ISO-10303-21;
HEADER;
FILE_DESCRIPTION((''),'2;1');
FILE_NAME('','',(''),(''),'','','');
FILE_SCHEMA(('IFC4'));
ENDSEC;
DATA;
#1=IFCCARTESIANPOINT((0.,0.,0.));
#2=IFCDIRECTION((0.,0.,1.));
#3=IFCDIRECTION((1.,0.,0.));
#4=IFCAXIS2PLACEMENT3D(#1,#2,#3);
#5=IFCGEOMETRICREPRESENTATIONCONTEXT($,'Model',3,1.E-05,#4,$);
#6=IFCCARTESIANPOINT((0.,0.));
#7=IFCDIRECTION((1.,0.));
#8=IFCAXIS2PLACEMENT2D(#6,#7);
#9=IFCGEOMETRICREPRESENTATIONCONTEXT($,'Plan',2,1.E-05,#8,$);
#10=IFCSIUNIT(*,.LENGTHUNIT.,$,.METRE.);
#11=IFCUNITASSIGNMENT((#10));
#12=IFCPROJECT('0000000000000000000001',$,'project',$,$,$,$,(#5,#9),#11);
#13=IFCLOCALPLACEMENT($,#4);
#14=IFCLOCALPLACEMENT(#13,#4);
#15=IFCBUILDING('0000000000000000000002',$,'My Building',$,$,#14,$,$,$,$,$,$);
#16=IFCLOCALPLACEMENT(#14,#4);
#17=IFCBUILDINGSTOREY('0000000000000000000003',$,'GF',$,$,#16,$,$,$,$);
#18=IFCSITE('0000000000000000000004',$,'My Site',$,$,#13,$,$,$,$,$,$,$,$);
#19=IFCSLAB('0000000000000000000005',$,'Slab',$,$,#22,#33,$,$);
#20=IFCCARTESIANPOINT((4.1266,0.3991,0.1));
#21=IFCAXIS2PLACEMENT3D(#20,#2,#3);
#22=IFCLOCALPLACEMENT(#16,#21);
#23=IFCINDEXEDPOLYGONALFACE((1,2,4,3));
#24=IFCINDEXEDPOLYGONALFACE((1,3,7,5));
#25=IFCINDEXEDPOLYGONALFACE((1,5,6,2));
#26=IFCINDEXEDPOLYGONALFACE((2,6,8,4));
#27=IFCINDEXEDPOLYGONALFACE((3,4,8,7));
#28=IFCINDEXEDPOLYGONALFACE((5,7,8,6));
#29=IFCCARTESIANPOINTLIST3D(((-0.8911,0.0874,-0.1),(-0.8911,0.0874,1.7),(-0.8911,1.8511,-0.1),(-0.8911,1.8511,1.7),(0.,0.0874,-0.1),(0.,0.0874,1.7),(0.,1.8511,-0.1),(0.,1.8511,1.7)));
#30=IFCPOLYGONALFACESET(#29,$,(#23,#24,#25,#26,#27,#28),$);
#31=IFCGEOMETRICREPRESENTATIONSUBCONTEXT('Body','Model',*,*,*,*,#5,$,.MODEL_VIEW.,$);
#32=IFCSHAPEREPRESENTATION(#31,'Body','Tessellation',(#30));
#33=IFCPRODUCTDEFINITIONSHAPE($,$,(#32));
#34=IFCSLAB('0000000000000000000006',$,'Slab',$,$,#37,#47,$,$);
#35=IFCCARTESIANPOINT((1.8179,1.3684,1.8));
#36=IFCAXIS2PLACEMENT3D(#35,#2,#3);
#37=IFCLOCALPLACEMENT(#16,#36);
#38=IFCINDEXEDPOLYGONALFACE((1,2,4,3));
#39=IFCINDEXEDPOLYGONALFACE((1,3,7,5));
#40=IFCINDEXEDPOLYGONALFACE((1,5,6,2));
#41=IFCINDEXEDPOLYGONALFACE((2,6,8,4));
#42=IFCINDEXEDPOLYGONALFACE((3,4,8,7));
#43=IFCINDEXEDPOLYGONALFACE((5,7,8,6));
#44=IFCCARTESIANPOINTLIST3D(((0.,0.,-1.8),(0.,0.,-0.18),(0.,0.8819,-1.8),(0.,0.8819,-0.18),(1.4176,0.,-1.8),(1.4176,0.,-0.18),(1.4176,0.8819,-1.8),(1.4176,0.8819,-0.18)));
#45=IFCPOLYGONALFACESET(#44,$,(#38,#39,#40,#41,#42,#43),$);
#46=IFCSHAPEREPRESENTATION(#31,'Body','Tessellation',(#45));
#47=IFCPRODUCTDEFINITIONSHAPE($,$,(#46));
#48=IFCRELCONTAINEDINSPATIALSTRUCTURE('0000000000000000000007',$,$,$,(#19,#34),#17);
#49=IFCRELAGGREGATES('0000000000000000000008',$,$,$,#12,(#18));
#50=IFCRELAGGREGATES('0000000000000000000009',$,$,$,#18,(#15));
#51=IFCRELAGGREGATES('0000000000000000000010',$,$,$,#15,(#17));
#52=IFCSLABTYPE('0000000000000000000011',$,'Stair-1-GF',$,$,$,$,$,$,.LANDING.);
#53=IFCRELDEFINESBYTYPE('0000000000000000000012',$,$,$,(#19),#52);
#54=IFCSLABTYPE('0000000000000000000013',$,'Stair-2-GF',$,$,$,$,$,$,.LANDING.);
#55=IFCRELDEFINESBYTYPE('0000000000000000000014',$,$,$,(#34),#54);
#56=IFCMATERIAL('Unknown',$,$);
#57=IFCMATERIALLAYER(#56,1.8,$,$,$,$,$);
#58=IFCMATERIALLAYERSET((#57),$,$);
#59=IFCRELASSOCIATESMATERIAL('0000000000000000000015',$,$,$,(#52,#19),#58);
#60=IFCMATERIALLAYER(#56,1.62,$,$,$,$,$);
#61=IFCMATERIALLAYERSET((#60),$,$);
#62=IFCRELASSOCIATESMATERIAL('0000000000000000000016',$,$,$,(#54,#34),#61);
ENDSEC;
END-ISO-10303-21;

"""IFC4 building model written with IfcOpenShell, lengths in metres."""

from ifc_helpers import new_model, si_unit, frame, origin_with_axes, origin_2d_with_axis, place, context, subcontext, project, spatial, indexed_curve, outline, extrude, material, layer, layer_set, layer_usage, type_object, element, save


model = new_model("IFC4")

# Units and contexts
model_context = context("Model", 3, precision=1e-05, world=origin_with_axes())
plan_context = context("Plan", 2, precision=1e-05, world=origin_2d_with_axis())
body_context_1 = subcontext(model_context, "Body", "Model", "MODEL_VIEW")
ifc_project = project(units=[si_unit("LENGTHUNIT", "METRE")], contexts=[model_context, plan_context])

# Site, building, storey
site_placement = place(None, origin_with_axes())
site = spatial("IfcSite", under=ifc_project, at=site_placement, Name="My Site")
building_placement = place(site_placement, origin_with_axes())
building = spatial("IfcBuilding", under=site, at=building_placement, Name="My Building")
storey_placement = place(building_placement, origin_with_axes())
storey = spatial("IfcBuildingStorey", under=building, at=storey_placement, Name="GF")

# Shared definitions
ifc_material = material(Name="Unknown")

# Slabs
ifc_layer_1 = layer(ifc_material, 1.8)
ifc_layer_set_1 = layer_set([ifc_layer_1])
ifc_layer_usage_1 = layer_usage(ifc_layer_set_1, "AXIS3", "POSITIVE", -0.1)
slab_type_1 = type_object("IfcSlabType", Name="Stair-1-GF", PredefinedType="LANDING", material=ifc_layer_set_1)
slab_1_placement = place(storey_placement, frame((4.1266, 0.3991, 0.1), z_axis=(0.0, 0.0, 1.0), x_axis=(1.0, 0.0, 0.0)))
element("IfcSlab", 1, at=slab_1_placement, inside=storey, type_object=slab_type_1, material=ifc_layer_usage_1, Name="Slab", context=body_context_1, shape_type="SweptSolid", body=[
    extrude(outline(indexed_curve([(0.0, 0.0874), (0.0, 1.8511), (-0.8911, 1.8511), (-0.8911, 0.0874), (0.0, 0.0874)])), frame((0.0, 0.0, -0.1), z_axis=(0.0, 0.0, 1.0), x_axis=(1.0, 0.0, 0.0)), (0.0, 0.0, 1.0), 1.8),
])
ifc_layer_2 = layer(ifc_material, 1.62)
ifc_layer_set_2 = layer_set([ifc_layer_2])
ifc_layer_usage_2 = layer_usage(ifc_layer_set_2, "AXIS3", "POSITIVE", -1.8)
slab_type_2 = type_object("IfcSlabType", Name="Stair-2-GF", PredefinedType="LANDING", material=ifc_layer_set_2)
slab_2_placement = place(storey_placement, frame((1.8179, 1.3684, 1.8), z_axis=(0.0, 0.0, 1.0), x_axis=(1.0, 0.0, 0.0)))
element("IfcSlab", 2, at=slab_2_placement, inside=storey, type_object=slab_type_2, material=ifc_layer_usage_2, Name="Slab", context=body_context_1, shape_type="SweptSolid", body=[
    extrude(outline(indexed_curve([(0.0, 0.8819), (1.4176, 0.8819), (1.4176, 0.0), (0.0, 0.0), (0.0, 0.8819)])), frame((0.0, 0.0, -1.8), z_axis=(0.0, 0.0, 1.0), x_axis=(1.0, 0.0, 0.0)), (0.0, 0.0, 1.0), 1.62),
])

save(model, "model.ifc")
